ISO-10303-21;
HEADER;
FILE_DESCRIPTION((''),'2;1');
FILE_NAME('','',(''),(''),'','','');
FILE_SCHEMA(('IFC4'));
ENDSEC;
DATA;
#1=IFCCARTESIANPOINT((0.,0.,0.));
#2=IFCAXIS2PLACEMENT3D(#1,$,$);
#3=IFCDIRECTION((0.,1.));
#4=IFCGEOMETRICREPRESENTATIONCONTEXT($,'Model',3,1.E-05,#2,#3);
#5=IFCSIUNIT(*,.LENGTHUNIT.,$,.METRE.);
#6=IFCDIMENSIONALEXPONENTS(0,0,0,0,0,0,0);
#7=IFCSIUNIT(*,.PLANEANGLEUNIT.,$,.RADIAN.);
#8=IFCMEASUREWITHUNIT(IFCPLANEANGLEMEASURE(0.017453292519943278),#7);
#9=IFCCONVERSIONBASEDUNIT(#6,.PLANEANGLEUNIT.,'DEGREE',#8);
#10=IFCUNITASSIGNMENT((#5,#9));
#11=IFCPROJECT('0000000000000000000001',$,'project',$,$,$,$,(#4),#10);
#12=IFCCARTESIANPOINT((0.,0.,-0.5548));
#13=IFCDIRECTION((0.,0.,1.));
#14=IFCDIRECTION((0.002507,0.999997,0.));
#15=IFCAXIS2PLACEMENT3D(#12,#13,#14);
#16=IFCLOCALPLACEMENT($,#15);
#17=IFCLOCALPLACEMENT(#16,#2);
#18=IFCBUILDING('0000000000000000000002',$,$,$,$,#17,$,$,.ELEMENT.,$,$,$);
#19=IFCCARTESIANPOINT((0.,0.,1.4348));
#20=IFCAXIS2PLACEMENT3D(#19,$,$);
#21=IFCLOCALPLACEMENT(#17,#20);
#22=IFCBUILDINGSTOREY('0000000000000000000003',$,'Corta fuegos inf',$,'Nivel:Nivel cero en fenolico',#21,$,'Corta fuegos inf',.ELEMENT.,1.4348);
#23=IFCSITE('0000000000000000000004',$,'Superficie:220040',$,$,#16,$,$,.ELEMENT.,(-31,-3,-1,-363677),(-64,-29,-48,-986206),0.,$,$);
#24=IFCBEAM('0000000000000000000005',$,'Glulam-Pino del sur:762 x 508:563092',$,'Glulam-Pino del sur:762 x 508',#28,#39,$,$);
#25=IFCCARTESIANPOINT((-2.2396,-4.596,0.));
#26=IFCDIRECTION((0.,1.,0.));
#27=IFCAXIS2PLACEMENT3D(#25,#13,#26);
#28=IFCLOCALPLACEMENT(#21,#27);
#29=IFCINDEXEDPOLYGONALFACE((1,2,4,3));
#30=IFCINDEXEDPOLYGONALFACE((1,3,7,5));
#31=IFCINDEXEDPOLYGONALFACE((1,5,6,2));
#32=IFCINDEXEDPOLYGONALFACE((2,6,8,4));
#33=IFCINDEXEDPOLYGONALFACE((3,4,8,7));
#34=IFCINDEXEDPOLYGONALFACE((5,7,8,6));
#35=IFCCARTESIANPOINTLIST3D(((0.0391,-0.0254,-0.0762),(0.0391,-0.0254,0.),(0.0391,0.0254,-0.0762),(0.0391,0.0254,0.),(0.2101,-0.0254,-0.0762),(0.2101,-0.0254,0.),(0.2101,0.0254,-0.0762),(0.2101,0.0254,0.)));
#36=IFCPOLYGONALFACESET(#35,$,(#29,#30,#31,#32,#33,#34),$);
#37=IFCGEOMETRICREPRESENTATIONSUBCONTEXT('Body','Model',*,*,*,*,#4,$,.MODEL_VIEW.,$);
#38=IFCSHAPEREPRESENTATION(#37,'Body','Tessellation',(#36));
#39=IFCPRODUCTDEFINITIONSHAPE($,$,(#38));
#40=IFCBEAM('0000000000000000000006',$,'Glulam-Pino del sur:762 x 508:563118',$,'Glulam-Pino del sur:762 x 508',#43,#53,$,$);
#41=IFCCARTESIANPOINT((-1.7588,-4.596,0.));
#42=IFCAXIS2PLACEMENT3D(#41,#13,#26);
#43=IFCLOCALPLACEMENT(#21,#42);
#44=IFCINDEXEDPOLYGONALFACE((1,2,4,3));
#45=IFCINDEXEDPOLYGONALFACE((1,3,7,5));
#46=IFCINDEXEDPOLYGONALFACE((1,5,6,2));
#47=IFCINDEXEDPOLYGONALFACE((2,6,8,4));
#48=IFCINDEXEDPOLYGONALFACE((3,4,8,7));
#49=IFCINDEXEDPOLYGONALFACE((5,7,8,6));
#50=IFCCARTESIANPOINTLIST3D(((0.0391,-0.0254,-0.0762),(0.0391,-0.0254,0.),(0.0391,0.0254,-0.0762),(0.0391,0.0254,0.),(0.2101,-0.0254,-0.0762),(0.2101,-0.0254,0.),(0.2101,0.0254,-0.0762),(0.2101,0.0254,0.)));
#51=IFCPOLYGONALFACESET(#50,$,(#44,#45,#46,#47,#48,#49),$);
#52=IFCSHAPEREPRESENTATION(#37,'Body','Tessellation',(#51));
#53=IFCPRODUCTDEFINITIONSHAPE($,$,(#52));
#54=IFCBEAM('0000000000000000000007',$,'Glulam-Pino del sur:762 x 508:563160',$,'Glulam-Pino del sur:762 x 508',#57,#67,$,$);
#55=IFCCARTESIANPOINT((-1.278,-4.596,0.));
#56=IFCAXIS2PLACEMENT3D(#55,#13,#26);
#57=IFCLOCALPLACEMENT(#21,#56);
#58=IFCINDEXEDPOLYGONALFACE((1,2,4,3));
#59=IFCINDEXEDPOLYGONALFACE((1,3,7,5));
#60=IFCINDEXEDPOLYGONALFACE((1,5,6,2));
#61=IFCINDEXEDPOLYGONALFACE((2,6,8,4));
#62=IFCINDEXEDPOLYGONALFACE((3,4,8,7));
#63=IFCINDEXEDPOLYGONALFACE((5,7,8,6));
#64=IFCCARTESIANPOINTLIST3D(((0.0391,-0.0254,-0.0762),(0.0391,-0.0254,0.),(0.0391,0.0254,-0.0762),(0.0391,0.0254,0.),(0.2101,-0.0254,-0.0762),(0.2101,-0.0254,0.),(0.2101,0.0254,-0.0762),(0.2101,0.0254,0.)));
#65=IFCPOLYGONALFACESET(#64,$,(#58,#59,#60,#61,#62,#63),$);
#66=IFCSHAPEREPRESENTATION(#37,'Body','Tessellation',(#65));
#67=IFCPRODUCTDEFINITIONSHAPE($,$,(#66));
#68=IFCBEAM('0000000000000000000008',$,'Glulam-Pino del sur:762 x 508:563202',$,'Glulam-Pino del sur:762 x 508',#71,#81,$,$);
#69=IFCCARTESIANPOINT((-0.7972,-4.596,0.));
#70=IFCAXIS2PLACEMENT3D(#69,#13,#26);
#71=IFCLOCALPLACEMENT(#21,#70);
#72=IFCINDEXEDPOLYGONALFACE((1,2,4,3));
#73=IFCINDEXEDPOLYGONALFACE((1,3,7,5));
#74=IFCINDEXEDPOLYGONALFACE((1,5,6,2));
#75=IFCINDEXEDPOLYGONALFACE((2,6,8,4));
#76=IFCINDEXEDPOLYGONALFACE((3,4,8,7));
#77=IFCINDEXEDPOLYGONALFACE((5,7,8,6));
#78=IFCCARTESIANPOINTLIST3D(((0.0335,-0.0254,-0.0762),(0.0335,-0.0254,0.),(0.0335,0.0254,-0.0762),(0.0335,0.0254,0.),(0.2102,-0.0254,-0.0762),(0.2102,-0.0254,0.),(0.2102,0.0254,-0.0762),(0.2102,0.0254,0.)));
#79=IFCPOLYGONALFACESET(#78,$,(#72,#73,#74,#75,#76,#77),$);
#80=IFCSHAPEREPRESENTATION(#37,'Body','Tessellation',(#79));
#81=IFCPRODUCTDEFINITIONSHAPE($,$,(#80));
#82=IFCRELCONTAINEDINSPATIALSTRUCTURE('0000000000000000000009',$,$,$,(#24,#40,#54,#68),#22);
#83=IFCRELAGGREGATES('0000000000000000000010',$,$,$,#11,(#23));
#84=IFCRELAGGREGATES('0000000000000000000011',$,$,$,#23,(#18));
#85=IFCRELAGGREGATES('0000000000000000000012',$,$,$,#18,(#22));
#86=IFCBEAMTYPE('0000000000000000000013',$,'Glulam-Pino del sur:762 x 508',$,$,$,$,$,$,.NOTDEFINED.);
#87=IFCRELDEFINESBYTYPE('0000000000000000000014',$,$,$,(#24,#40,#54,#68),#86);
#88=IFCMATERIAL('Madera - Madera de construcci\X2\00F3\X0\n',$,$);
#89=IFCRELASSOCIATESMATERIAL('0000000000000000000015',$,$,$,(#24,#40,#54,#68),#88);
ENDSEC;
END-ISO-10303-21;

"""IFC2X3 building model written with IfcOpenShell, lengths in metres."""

from ifc_helpers import new_model, entity, si_unit, converted_unit, direction, frame, origin, origin_2d_with_axis, place, context, subcontext, project, spatial, rectangle, extrude, material, type_object, element, save


model = new_model("IFC2X3")

# Units and contexts
model_context = context("Model", 3, precision=1e-05, world=origin(), true_north=direction((0.0, 1.0)))
body_context = subcontext(model_context, "Body", "Model", "MODEL_VIEW")
ifc_project = project(units=[si_unit("LENGTHUNIT", "METRE"), converted_unit("PLANEANGLEUNIT", "DEGREE", entity("IfcPlaneAngleMeasure", 0.017453292519943278), si_unit("PLANEANGLEUNIT", "RADIAN"), dimensions=[0, 0, 0, 0, 0, 0, 0])], contexts=[model_context])

# Site, building, storey
site_placement = place(None, frame((0.0, 0.0, -0.5548), z_axis=(0.0, 0.0, 1.0), x_axis=(0.002507, 0.999997, 0.0)))
site = spatial("IfcSite", under=ifc_project, at=site_placement, Name="Superficie:220040", CompositionType="ELEMENT", RefLatitude=(-31, -3, -1, -363677), RefLongitude=(-64, -29, -48, -986206), RefElevation=0.0)
building_placement = place(site_placement, origin())
building = spatial("IfcBuilding", under=site, at=building_placement, CompositionType="ELEMENT")
storey_placement = place(building_placement, frame((0.0, 0.0, 1.4348)))
storey = spatial("IfcBuildingStorey", under=building, at=storey_placement, Name="Corta fuegos inf", ObjectType="Nivel:Nivel cero en fenolico", LongName="Corta fuegos inf", CompositionType="ELEMENT", Elevation=1.4348)

# Shared definitions
ifc_material_1 = material(Name="Madera - Madera de construcción")

# Beams
beam_type_1 = type_object("IfcBeamType", Name="Glulam-Pino del sur:762 x 508", PredefinedType="NOTDEFINED")
beam_1_placement = place(storey_placement, frame((-2.2396, -4.596, 0.0), z_axis=(0.0, 0.0, 1.0), x_axis=(0.0, 1.0, 0.0)))
element("IfcBeam", 1, at=beam_1_placement, inside=storey, type_object=beam_type_1, material=ifc_material_1, Name="Glulam-Pino del sur:762 x 508:563092", ObjectType="Glulam-Pino del sur:762 x 508", context=body_context, shape_type="SweptSolid", body=[
    extrude(rectangle(XDim=0.0762, YDim=0.0508, at=origin_2d_with_axis()), frame((0.0391, 0.0, -0.0381), z_axis=(1.0, 0.0, 0.0), x_axis=(0.0, 0.0, -1.0)), (0.0, 0.0, 1.0), 0.171),
])
beam_2_placement = place(storey_placement, frame((-1.7588, -4.596, 0.0), z_axis=(0.0, 0.0, 1.0), x_axis=(0.0, 1.0, 0.0)))
element("IfcBeam", 2, at=beam_2_placement, inside=storey, type_object=beam_type_1, material=ifc_material_1, Name="Glulam-Pino del sur:762 x 508:563118", ObjectType="Glulam-Pino del sur:762 x 508", context=body_context, shape_type="SweptSolid", body=[
    extrude(rectangle(XDim=0.0762, YDim=0.0508, at=origin_2d_with_axis()), frame((0.0391, 0.0, -0.0381), z_axis=(1.0, 0.0, 0.0), x_axis=(0.0, 0.0, -1.0)), (0.0, 0.0, 1.0), 0.171),
])
beam_3_placement = place(storey_placement, frame((-1.278, -4.596, 0.0), z_axis=(0.0, 0.0, 1.0), x_axis=(0.0, 1.0, 0.0)))
element("IfcBeam", 3, at=beam_3_placement, inside=storey, type_object=beam_type_1, material=ifc_material_1, Name="Glulam-Pino del sur:762 x 508:563160", ObjectType="Glulam-Pino del sur:762 x 508", context=body_context, shape_type="SweptSolid", body=[
    extrude(rectangle(XDim=0.0762, YDim=0.0508, at=origin_2d_with_axis()), frame((0.0391, 0.0, -0.0381), z_axis=(1.0, 0.0, 0.0), x_axis=(0.0, 0.0, -1.0)), (0.0, 0.0, 1.0), 0.171),
])
beam_4_placement = place(storey_placement, frame((-0.7972, -4.596, 0.0), z_axis=(0.0, 0.0, 1.0), x_axis=(0.0, 1.0, 0.0)))
element("IfcBeam", 4, at=beam_4_placement, inside=storey, type_object=beam_type_1, material=ifc_material_1, Name="Glulam-Pino del sur:762 x 508:563202", ObjectType="Glulam-Pino del sur:762 x 508", context=body_context, shape_type="SweptSolid", body=[
    extrude(rectangle(XDim=0.0762, YDim=0.0508, at=origin_2d_with_axis()), frame((0.0335, 0.0, -0.0381), z_axis=(1.0, 0.0, 0.0), x_axis=(0.0, 0.0, -1.0)), (0.0, 0.0, 1.0), 0.1767),
])

save(model, "model.ifc")
